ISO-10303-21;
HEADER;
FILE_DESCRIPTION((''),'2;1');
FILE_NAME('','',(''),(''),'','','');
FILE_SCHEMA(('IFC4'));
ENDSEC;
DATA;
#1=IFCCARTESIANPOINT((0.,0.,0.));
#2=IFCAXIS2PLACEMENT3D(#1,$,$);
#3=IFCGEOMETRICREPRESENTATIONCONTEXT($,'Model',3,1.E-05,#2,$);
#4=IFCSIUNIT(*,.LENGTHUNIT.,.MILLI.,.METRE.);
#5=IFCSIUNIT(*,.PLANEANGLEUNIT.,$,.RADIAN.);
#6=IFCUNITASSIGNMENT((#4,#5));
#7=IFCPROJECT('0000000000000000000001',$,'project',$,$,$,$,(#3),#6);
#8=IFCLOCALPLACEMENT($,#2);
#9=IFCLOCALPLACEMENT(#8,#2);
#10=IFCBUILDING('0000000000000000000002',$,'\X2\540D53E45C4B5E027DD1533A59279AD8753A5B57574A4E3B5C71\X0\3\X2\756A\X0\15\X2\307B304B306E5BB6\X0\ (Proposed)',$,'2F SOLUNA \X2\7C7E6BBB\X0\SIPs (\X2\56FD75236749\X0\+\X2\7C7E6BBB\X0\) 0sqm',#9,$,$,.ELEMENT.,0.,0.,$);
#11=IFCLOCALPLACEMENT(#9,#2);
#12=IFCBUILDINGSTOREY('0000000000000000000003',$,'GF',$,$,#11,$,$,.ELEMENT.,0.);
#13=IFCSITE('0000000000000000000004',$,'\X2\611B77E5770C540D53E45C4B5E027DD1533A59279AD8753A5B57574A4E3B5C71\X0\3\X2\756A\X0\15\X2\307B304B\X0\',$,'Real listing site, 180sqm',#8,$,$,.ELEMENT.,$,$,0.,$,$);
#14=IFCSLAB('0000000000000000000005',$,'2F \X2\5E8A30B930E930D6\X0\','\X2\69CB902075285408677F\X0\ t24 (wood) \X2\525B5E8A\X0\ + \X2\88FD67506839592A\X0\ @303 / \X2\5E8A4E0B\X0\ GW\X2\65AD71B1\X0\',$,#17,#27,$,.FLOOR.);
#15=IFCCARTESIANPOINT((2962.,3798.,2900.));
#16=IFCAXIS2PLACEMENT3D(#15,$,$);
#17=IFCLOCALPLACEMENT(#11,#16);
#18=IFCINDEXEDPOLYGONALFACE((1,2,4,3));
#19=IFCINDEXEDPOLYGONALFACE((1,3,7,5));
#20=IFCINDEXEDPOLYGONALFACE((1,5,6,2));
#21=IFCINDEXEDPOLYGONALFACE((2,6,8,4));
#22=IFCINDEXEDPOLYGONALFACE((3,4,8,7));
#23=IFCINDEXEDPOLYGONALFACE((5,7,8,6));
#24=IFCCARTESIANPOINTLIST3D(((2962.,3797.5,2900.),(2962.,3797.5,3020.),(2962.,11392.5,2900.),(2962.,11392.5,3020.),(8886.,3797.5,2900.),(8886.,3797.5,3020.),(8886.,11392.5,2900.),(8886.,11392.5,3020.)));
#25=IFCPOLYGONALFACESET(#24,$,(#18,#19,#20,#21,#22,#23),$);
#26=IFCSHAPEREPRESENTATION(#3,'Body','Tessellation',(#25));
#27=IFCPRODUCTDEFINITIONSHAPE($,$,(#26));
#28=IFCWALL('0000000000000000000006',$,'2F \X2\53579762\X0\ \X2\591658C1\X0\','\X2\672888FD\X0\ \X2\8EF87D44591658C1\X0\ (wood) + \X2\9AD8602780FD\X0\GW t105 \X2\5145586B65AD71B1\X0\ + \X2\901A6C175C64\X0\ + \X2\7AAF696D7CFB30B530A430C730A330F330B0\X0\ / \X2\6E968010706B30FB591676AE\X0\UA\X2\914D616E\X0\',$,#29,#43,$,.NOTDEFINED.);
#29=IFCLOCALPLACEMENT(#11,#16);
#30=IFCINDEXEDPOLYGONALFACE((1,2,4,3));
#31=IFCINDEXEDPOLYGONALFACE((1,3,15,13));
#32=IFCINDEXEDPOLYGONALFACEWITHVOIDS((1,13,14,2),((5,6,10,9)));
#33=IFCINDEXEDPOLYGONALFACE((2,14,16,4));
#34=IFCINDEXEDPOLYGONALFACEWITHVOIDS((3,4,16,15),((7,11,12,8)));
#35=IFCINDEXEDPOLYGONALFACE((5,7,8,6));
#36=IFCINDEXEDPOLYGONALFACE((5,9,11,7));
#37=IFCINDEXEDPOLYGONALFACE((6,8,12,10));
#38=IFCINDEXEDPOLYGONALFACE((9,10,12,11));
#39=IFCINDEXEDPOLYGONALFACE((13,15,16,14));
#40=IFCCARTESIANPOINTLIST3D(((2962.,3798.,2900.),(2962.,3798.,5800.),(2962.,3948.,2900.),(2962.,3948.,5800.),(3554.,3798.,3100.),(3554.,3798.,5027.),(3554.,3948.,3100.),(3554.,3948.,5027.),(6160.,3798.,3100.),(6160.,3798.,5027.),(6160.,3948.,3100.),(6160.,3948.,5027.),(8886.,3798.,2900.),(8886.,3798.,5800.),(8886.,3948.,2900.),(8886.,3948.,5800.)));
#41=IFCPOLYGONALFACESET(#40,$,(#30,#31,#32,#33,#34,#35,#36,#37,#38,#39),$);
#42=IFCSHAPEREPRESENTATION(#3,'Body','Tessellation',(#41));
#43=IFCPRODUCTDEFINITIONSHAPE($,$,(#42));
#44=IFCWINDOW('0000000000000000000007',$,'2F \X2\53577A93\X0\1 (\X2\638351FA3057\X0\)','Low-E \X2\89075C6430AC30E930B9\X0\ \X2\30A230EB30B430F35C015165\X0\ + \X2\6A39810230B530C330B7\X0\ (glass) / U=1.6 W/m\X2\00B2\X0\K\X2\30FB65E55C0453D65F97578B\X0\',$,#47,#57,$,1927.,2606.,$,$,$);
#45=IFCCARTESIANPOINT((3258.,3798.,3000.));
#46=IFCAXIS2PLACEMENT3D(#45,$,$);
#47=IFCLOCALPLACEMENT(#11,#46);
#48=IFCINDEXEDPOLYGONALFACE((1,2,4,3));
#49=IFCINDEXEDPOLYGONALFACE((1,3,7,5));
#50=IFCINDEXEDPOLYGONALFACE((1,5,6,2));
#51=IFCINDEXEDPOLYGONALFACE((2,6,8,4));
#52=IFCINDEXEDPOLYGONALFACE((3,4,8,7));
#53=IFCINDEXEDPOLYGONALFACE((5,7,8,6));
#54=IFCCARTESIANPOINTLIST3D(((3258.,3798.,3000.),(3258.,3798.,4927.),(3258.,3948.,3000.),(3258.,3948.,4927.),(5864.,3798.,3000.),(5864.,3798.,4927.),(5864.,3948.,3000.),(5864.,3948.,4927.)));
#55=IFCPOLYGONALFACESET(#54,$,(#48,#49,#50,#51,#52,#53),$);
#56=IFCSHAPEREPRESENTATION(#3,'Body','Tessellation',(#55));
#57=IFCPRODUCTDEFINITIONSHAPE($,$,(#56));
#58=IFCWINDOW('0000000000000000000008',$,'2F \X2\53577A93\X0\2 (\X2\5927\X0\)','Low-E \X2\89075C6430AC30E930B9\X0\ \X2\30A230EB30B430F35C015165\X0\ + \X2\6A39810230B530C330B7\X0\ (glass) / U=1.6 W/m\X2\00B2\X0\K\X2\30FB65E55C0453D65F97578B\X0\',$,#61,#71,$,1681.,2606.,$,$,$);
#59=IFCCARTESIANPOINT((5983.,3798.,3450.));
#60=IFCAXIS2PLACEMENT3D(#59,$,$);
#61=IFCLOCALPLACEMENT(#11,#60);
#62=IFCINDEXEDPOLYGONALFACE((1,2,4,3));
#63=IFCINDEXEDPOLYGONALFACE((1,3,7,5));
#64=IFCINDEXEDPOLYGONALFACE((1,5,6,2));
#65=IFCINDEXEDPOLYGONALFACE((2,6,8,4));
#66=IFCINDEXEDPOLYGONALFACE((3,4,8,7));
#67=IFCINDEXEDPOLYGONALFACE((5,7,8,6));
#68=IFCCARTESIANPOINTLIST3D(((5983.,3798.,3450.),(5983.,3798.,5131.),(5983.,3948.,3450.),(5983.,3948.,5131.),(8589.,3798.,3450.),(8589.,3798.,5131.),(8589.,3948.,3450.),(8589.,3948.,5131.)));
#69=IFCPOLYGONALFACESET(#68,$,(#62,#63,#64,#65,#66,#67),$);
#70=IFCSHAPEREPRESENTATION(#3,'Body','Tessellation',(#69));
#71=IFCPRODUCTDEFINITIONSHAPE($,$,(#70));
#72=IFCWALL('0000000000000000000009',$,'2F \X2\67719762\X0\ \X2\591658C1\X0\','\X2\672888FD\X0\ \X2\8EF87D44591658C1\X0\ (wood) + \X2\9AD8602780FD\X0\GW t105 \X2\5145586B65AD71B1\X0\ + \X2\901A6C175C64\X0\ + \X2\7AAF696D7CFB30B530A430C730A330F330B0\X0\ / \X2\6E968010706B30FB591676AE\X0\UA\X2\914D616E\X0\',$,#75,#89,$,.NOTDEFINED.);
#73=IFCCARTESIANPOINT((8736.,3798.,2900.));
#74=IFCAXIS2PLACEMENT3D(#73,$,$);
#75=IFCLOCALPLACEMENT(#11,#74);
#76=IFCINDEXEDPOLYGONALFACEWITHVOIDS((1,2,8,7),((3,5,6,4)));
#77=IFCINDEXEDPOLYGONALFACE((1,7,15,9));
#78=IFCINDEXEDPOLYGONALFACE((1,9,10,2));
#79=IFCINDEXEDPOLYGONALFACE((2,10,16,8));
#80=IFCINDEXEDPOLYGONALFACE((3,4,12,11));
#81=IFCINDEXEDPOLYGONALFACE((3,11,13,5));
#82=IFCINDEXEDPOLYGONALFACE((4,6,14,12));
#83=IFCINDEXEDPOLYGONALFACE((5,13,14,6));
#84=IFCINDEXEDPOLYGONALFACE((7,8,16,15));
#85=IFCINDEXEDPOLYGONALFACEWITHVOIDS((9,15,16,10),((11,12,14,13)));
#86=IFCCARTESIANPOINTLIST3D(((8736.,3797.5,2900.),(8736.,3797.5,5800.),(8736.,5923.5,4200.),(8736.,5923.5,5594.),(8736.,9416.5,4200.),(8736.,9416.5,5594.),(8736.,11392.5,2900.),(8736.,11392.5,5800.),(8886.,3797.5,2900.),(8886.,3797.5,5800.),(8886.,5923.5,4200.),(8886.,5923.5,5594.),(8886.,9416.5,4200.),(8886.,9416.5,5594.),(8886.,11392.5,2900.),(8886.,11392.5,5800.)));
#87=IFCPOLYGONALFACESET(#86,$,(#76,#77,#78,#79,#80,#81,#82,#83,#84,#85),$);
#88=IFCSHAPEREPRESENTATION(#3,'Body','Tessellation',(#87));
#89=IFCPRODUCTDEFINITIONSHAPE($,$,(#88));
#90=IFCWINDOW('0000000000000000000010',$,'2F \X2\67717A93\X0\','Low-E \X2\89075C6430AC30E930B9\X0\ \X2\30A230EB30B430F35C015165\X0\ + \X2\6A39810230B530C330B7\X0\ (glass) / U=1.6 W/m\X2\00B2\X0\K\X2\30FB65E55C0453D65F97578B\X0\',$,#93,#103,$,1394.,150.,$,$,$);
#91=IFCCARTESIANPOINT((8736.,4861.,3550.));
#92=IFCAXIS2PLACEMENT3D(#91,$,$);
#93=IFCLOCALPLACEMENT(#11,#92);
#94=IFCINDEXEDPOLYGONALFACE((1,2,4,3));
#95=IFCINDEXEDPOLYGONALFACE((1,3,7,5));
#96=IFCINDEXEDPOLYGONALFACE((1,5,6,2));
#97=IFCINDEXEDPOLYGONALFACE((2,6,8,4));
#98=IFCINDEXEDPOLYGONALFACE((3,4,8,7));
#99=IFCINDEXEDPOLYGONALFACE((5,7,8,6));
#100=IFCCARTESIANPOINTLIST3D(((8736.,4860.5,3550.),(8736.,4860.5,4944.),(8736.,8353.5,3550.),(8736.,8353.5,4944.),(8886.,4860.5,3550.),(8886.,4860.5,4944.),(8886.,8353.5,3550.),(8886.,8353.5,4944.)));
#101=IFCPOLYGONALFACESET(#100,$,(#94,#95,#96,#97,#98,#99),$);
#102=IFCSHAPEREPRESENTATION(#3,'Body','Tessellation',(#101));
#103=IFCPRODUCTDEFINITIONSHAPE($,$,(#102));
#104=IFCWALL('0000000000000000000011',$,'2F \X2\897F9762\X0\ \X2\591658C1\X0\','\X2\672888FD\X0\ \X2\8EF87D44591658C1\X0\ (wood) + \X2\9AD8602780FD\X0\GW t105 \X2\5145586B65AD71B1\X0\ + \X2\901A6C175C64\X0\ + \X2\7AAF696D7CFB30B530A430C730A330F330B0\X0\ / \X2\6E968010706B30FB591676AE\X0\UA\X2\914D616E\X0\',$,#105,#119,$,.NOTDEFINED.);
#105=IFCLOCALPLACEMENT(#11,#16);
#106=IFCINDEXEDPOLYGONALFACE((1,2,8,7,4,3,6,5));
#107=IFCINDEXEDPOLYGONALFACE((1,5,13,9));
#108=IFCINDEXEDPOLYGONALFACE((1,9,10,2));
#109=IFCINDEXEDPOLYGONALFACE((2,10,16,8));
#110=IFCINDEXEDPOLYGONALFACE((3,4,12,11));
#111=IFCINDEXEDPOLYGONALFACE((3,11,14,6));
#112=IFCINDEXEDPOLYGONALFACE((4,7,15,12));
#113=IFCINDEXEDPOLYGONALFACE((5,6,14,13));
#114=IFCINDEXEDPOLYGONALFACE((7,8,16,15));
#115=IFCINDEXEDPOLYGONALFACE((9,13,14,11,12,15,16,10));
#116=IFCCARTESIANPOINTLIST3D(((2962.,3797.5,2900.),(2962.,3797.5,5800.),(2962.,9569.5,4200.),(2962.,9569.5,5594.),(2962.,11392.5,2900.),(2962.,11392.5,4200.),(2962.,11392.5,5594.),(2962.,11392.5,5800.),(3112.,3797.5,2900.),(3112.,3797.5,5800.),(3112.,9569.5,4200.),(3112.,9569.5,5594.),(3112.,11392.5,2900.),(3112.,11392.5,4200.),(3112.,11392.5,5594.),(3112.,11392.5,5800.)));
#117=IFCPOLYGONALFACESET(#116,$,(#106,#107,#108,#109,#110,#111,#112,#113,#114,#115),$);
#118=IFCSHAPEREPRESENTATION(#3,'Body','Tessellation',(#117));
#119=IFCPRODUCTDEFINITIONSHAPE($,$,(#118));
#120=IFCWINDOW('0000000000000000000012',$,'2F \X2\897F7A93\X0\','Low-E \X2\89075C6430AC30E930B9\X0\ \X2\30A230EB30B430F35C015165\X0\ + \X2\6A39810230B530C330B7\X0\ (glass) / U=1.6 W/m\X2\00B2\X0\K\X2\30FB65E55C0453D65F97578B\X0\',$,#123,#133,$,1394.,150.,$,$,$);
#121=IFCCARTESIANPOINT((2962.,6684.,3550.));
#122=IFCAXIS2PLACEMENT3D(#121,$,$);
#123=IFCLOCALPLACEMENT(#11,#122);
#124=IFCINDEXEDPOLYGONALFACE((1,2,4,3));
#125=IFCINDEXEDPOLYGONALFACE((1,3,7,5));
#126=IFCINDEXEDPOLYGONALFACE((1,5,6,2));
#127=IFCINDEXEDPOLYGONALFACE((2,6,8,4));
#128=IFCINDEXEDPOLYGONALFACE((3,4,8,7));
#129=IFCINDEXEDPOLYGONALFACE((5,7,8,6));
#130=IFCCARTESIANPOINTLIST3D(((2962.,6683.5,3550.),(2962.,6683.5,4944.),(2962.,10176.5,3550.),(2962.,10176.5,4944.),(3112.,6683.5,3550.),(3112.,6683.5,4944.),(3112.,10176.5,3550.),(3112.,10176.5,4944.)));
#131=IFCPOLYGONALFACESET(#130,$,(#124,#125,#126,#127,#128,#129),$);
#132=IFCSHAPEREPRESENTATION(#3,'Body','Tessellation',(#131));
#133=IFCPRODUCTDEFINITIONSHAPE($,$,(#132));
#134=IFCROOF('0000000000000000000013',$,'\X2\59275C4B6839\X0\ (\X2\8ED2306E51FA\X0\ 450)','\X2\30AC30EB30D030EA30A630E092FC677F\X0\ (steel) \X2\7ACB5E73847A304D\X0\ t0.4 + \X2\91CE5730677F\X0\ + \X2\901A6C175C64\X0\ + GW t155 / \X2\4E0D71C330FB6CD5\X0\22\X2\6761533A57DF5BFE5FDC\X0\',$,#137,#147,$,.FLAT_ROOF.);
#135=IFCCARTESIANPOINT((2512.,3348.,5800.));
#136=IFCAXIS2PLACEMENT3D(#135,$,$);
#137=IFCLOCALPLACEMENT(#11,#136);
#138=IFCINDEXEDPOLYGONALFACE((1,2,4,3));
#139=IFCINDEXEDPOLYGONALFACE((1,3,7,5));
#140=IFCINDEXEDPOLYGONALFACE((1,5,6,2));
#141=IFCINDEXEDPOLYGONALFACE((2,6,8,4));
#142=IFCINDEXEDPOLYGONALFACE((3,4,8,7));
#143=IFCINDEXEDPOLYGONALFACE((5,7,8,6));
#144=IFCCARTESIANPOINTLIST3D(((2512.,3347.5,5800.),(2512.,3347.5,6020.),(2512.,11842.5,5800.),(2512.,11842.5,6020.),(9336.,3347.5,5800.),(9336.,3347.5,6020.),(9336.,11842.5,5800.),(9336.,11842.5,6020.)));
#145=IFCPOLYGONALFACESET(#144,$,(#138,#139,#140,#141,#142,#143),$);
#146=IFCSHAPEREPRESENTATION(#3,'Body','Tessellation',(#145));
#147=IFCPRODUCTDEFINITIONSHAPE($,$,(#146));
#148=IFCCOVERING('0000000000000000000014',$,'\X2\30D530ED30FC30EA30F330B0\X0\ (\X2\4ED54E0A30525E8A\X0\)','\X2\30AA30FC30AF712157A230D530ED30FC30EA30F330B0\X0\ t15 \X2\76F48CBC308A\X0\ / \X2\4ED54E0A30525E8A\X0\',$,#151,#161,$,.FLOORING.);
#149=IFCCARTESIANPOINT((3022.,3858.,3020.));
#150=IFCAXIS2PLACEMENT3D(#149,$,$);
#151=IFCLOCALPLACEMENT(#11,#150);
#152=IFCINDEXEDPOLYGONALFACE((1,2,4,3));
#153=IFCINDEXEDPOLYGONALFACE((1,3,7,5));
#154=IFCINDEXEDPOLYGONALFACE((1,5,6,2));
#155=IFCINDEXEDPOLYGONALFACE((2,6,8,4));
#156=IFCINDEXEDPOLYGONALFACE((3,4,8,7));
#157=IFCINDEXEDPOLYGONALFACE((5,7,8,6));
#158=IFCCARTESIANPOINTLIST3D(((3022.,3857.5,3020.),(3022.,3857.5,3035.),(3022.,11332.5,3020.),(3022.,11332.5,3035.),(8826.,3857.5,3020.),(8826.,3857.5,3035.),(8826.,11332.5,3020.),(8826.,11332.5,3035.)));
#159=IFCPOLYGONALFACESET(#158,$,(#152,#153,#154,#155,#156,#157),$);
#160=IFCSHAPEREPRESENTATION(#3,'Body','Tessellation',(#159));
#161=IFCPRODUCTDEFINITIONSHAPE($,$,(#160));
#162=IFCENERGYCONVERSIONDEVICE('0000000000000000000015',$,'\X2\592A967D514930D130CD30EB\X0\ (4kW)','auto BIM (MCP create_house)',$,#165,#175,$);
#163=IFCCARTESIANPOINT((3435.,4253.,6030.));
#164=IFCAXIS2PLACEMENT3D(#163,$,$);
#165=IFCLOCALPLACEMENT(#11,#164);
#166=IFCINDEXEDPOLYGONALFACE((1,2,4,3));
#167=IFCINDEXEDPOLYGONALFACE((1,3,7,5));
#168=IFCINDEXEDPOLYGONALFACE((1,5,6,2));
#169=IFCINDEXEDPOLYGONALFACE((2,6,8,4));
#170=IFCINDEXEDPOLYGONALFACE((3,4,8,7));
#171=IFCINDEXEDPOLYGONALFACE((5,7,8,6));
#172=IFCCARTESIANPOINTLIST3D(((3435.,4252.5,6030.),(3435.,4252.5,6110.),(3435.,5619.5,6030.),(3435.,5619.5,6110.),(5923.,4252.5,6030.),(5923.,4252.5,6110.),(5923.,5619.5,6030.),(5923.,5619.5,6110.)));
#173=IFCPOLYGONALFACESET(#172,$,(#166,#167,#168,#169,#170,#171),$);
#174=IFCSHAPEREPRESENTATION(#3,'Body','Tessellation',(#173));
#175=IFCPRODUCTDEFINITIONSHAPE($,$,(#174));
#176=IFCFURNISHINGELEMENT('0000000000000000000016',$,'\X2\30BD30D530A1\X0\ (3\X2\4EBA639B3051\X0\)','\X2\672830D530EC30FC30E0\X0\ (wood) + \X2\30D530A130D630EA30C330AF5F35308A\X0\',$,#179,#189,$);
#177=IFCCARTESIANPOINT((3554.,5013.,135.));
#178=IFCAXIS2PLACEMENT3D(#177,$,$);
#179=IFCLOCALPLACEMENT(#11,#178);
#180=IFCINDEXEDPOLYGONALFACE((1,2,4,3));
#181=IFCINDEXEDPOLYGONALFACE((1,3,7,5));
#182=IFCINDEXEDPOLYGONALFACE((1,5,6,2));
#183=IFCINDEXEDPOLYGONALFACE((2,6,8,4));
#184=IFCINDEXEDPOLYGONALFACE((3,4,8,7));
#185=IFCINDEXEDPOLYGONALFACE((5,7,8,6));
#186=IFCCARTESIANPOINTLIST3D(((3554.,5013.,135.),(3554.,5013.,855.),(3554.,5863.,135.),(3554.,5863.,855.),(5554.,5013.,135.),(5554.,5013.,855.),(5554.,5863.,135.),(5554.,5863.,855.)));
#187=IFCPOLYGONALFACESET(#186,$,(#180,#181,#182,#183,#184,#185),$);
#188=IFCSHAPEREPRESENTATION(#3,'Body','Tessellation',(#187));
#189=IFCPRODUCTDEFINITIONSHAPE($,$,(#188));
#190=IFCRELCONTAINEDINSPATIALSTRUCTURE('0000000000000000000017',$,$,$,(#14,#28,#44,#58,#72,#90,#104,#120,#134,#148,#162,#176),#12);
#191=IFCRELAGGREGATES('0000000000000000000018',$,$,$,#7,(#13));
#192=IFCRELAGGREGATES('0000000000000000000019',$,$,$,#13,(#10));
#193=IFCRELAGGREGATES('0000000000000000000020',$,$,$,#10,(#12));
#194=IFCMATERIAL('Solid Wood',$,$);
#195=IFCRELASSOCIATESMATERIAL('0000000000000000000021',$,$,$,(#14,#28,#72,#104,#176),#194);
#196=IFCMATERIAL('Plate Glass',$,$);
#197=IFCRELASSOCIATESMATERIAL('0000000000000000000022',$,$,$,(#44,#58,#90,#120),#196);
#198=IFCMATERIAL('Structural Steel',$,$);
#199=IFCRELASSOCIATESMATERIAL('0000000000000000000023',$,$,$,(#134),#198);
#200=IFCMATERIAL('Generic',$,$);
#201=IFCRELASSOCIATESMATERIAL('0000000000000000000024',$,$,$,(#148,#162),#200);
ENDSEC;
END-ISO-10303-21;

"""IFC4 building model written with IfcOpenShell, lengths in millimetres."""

from ifc_helpers import new_model, si_unit, frame, frame_2d, origin, place, context, project, spatial, rectangle, extrude, material, element, fill, save


model = new_model("IFC4")

# Units and contexts
model_context = context("Model", 3, precision=1e-05, world=origin())
ifc_project = project(units=[si_unit("LENGTHUNIT", "METRE", prefix="MILLI"), si_unit("PLANEANGLEUNIT", "RADIAN")], contexts=[model_context])

# Site, building, storey
site_placement = place(None, origin())
site = spatial("IfcSite", under=ifc_project, at=site_placement, Name="愛知県名古屋市緑区大高町字坊主山3番15ほか", ObjectType="Real listing site, 180sqm", CompositionType="ELEMENT", RefElevation=0.0)
building_placement = place(site_placement, origin())
building = spatial("IfcBuilding", under=site, at=building_placement, Name="名古屋市緑区大高町字坊主山3番15ほかの家 (Proposed)", ObjectType="2F SOLUNA 籾殻SIPs (国産杉+籾殻) 0sqm", CompositionType="ELEMENT", ElevationOfRefHeight=0.0, ElevationOfTerrain=0.0)
storey_placement = place(building_placement, origin())
storey = spatial("IfcBuildingStorey", under=building, at=storey_placement, Name="GF", CompositionType="ELEMENT", Elevation=0.0)

# Slab
ifc_material_1 = material(Name="Solid Wood")
slab_placement = place(storey_placement, frame((2962.0, 3798.0, 2900.0)))
element("IfcSlab", 1, at=slab_placement, inside=storey, material=ifc_material_1, Name="2F 床スラブ", Description="構造用合板 t24 (wood) 剛床 + 製材根太 @303 / 床下 GW断熱", PredefinedType="FLOOR", context=model_context, shape_type="SweptSolid", body=[
    extrude(rectangle(XDim=5924.0, YDim=7595.0, at=frame_2d((2962.0, 3797.0))), frame((2962.0, 3798.0, 2900.0)), (0.0, 0.0, 1.0), 120.0),
])

# Wall, openings, windows
wall_1_placement = place(storey_placement, frame((2962.0, 3798.0, 2900.0)))
wall_1 = element("IfcWall", 2, at=wall_1_placement, inside=storey, material=ifc_material_1, Name="2F 南面 外壁", Description="木製 軸組外壁 (wood) + 高性能GW t105 充填断熱 + 通気層 + 窯業系サイディング / 準耐火・外皮UA配慮", PredefinedType="NOTDEFINED", context=model_context, shape_type="SweptSolid", body=[
    extrude(rectangle(XDim=5924.0, YDim=150.0, at=frame_2d((2962.0, 75.0))), frame((2962.0, 3798.0, 2900.0)), (0.0, 0.0, 1.0), 2900.0),
])
opening_1_placement = place(storey_placement, frame((3258.0, 3798.0, 3000.0)))
opening_1 = element("IfcOpeningElement", 3, at=opening_1_placement, cuts=wall_1, PredefinedType="NOTDEFINED", context=model_context, shape_type="SweptSolid", body=[
    extrude(rectangle(XDim=2606.0, YDim=150.0, at=frame_2d((1303.0, 75.0))), frame((3258.0, 3798.0, 3000.0)), (0.0, 0.0, 1.0), 1927.0),
])
opening_2_placement = place(storey_placement, frame((5983.0, 3798.0, 3450.0)))
opening_2 = element("IfcOpeningElement", 4, at=opening_2_placement, cuts=wall_1, PredefinedType="NOTDEFINED", context=model_context, shape_type="SweptSolid", body=[
    extrude(rectangle(XDim=2606.0, YDim=150.0, at=frame_2d((1303.0, 75.0))), frame((5983.0, 3798.0, 3450.0)), (0.0, 0.0, 1.0), 1681.0),
])
ifc_material_2 = material(Name="Plate Glass")
window_1_placement = place(storey_placement, frame((3258.0, 3798.0, 3000.0)))
window_1 = element("IfcWindow", 5, at=window_1_placement, inside=storey, material=ifc_material_2, Name="2F 南窓1 (掃出し)", Description="Low-E 複層ガラス アルゴン封入 + 樹脂サッシ (glass) / U=1.6 W/m²K・日射取得型", OverallHeight=1927.0, OverallWidth=2606.0, context=model_context, shape_type="SweptSolid", body=[
    extrude(rectangle(XDim=2606.0, YDim=150.0, at=frame_2d((1303.0, 75.0))), frame((3258.0, 3798.0, 3000.0)), (0.0, 0.0, 1.0), 1927.0),
])
fill(opening_1, window_1)
window_2_placement = place(storey_placement, frame((5983.0, 3798.0, 3450.0)))
window_2 = element("IfcWindow", 6, at=window_2_placement, inside=storey, material=ifc_material_2, Name="2F 南窓2 (大)", Description="Low-E 複層ガラス アルゴン封入 + 樹脂サッシ (glass) / U=1.6 W/m²K・日射取得型", OverallHeight=1681.0, OverallWidth=2606.0, context=model_context, shape_type="SweptSolid", body=[
    extrude(rectangle(XDim=2606.0, YDim=150.0, at=frame_2d((1303.0, 75.0))), frame((5983.0, 3798.0, 3450.0)), (0.0, 0.0, 1.0), 1681.0),
])
fill(opening_2, window_2)

# Walls, openings, windows
wall_2_placement = place(storey_placement, frame((8736.0, 3798.0, 2900.0)))
wall_2 = element("IfcWall", 7, at=wall_2_placement, inside=storey, material=ifc_material_1, Name="2F 東面 外壁", Description="木製 軸組外壁 (wood) + 高性能GW t105 充填断熱 + 通気層 + 窯業系サイディング / 準耐火・外皮UA配慮", PredefinedType="NOTDEFINED", context=model_context, shape_type="SweptSolid", body=[
    extrude(rectangle(XDim=150.0, YDim=7595.0, at=frame_2d((75.0, 3797.0))), frame((8736.0, 3798.0, 2900.0)), (0.0, 0.0, 1.0), 2900.0),
])
opening_3_placement = place(storey_placement, frame((8736.0, 4861.0, 3550.0)))
opening_3 = element("IfcOpeningElement", 8, at=opening_3_placement, cuts=wall_2, PredefinedType="NOTDEFINED", context=model_context, shape_type="SweptSolid", body=[
    extrude(rectangle(XDim=150.0, YDim=3493.0, at=frame_2d((75.0, 1746.0))), frame((8736.0, 4861.0, 3550.0)), (0.0, 0.0, 1.0), 1394.0),
])
window_3_placement = place(storey_placement, frame((8736.0, 4861.0, 3550.0)))
window_3 = element("IfcWindow", 9, at=window_3_placement, inside=storey, material=ifc_material_2, Name="2F 東窓", Description="Low-E 複層ガラス アルゴン封入 + 樹脂サッシ (glass) / U=1.6 W/m²K・日射取得型", OverallHeight=1394.0, OverallWidth=150.0, context=model_context, shape_type="SweptSolid", body=[
    extrude(rectangle(XDim=150.0, YDim=3493.0, at=frame_2d((75.0, 1746.0))), frame((8736.0, 4861.0, 3550.0)), (0.0, 0.0, 1.0), 1394.0),
])
fill(opening_3, window_3)
wall_3_placement = place(storey_placement, frame((2962.0, 3798.0, 2900.0)))
wall_3 = element("IfcWall", 10, at=wall_3_placement, inside=storey, material=ifc_material_1, Name="2F 西面 外壁", Description="木製 軸組外壁 (wood) + 高性能GW t105 充填断熱 + 通気層 + 窯業系サイディング / 準耐火・外皮UA配慮", PredefinedType="NOTDEFINED", context=model_context, shape_type="SweptSolid", body=[
    extrude(rectangle(XDim=150.0, YDim=7595.0, at=frame_2d((75.0, 3797.0))), frame((2962.0, 3798.0, 2900.0)), (0.0, 0.0, 1.0), 2900.0),
])
opening_4_placement = place(storey_placement, frame((2962.0, 6684.0, 3550.0)))
opening_4 = element("IfcOpeningElement", 11, at=opening_4_placement, cuts=wall_3, PredefinedType="NOTDEFINED", context=model_context, shape_type="SweptSolid", body=[
    extrude(rectangle(XDim=150.0, YDim=3493.0, at=frame_2d((75.0, 1746.0))), frame((2962.0, 6684.0, 3550.0)), (0.0, 0.0, 1.0), 1394.0),
])
window_4_placement = place(storey_placement, frame((2962.0, 6684.0, 3550.0)))
window_4 = element("IfcWindow", 12, at=window_4_placement, inside=storey, material=ifc_material_2, Name="2F 西窓", Description="Low-E 複層ガラス アルゴン封入 + 樹脂サッシ (glass) / U=1.6 W/m²K・日射取得型", OverallHeight=1394.0, OverallWidth=150.0, context=model_context, shape_type="SweptSolid", body=[
    extrude(rectangle(XDim=150.0, YDim=3493.0, at=frame_2d((75.0, 1746.0))), frame((2962.0, 6684.0, 3550.0)), (0.0, 0.0, 1.0), 1394.0),
])
fill(opening_4, window_4)

# Roof
ifc_material_3 = material(Name="Structural Steel")
roof_placement = place(storey_placement, frame((2512.0, 3348.0, 5800.0)))
element("IfcRoof", 13, at=roof_placement, inside=storey, material=ifc_material_3, Name="大屋根 (軒の出 450)", Description="ガルバリウム鋼板 (steel) 立平葺き t0.4 + 野地板 + 通気層 + GW t155 / 不燃・法22条区域対応", PredefinedType="FLAT_ROOF", context=model_context, shape_type="SweptSolid", body=[
    extrude(rectangle(XDim=6824.0, YDim=8495.0, at=frame_2d((3412.0, 4247.0))), frame((2512.0, 3348.0, 5800.0)), (0.0, 0.0, 1.0), 220.0),
])

# Covering
ifc_material_4 = material(Name="Generic")
covering_placement = place(storey_placement, frame((3022.0, 3858.0, 3020.0)))
element("IfcCovering", 14, at=covering_placement, inside=storey, material=ifc_material_4, Name="フローリング (仕上げ床)", Description="オーク無垢フローリング t15 直貼り / 仕上げ床", PredefinedType="FLOORING", context=model_context, shape_type="SweptSolid", body=[
    extrude(rectangle(XDim=5804.0, YDim=7475.0, at=frame_2d((2902.0, 3737.0))), frame((3022.0, 3858.0, 3020.0)), (0.0, 0.0, 1.0), 15.0),
])

# Energy conversion device
energy_conversion_device_placement = place(storey_placement, frame((3435.0, 4253.0, 6030.0)))
element("IfcEnergyConversionDevice", 15, at=energy_conversion_device_placement, inside=storey, material=ifc_material_4, Name="太陽光パネル (4kW)", Description="auto BIM (MCP create_house)", context=model_context, shape_type="SweptSolid", body=[
    extrude(rectangle(XDim=2488.0, YDim=1367.0, at=frame_2d((1244.0, 683.0))), frame((3435.0, 4253.0, 6030.0)), (0.0, 0.0, 1.0), 80.0),
])

# Furnishing element
furnishing_1_placement = place(storey_placement, frame((3554.0, 5013.0, 135.0)))
element("IfcFurnishingElement", 16, at=furnishing_1_placement, inside=storey, material=ifc_material_1, Name="ソファ (3人掛け)", Description="木フレーム (wood) + ファブリック張り", context=model_context, shape_type="SweptSolid", body=[
    extrude(rectangle(XDim=2000.0, YDim=850.0, at=frame_2d((1000.0, 425.0))), frame((3554.0, 5013.0, 135.0)), (0.0, 0.0, 1.0), 720.0),
])

save(model, "model.ifc")
